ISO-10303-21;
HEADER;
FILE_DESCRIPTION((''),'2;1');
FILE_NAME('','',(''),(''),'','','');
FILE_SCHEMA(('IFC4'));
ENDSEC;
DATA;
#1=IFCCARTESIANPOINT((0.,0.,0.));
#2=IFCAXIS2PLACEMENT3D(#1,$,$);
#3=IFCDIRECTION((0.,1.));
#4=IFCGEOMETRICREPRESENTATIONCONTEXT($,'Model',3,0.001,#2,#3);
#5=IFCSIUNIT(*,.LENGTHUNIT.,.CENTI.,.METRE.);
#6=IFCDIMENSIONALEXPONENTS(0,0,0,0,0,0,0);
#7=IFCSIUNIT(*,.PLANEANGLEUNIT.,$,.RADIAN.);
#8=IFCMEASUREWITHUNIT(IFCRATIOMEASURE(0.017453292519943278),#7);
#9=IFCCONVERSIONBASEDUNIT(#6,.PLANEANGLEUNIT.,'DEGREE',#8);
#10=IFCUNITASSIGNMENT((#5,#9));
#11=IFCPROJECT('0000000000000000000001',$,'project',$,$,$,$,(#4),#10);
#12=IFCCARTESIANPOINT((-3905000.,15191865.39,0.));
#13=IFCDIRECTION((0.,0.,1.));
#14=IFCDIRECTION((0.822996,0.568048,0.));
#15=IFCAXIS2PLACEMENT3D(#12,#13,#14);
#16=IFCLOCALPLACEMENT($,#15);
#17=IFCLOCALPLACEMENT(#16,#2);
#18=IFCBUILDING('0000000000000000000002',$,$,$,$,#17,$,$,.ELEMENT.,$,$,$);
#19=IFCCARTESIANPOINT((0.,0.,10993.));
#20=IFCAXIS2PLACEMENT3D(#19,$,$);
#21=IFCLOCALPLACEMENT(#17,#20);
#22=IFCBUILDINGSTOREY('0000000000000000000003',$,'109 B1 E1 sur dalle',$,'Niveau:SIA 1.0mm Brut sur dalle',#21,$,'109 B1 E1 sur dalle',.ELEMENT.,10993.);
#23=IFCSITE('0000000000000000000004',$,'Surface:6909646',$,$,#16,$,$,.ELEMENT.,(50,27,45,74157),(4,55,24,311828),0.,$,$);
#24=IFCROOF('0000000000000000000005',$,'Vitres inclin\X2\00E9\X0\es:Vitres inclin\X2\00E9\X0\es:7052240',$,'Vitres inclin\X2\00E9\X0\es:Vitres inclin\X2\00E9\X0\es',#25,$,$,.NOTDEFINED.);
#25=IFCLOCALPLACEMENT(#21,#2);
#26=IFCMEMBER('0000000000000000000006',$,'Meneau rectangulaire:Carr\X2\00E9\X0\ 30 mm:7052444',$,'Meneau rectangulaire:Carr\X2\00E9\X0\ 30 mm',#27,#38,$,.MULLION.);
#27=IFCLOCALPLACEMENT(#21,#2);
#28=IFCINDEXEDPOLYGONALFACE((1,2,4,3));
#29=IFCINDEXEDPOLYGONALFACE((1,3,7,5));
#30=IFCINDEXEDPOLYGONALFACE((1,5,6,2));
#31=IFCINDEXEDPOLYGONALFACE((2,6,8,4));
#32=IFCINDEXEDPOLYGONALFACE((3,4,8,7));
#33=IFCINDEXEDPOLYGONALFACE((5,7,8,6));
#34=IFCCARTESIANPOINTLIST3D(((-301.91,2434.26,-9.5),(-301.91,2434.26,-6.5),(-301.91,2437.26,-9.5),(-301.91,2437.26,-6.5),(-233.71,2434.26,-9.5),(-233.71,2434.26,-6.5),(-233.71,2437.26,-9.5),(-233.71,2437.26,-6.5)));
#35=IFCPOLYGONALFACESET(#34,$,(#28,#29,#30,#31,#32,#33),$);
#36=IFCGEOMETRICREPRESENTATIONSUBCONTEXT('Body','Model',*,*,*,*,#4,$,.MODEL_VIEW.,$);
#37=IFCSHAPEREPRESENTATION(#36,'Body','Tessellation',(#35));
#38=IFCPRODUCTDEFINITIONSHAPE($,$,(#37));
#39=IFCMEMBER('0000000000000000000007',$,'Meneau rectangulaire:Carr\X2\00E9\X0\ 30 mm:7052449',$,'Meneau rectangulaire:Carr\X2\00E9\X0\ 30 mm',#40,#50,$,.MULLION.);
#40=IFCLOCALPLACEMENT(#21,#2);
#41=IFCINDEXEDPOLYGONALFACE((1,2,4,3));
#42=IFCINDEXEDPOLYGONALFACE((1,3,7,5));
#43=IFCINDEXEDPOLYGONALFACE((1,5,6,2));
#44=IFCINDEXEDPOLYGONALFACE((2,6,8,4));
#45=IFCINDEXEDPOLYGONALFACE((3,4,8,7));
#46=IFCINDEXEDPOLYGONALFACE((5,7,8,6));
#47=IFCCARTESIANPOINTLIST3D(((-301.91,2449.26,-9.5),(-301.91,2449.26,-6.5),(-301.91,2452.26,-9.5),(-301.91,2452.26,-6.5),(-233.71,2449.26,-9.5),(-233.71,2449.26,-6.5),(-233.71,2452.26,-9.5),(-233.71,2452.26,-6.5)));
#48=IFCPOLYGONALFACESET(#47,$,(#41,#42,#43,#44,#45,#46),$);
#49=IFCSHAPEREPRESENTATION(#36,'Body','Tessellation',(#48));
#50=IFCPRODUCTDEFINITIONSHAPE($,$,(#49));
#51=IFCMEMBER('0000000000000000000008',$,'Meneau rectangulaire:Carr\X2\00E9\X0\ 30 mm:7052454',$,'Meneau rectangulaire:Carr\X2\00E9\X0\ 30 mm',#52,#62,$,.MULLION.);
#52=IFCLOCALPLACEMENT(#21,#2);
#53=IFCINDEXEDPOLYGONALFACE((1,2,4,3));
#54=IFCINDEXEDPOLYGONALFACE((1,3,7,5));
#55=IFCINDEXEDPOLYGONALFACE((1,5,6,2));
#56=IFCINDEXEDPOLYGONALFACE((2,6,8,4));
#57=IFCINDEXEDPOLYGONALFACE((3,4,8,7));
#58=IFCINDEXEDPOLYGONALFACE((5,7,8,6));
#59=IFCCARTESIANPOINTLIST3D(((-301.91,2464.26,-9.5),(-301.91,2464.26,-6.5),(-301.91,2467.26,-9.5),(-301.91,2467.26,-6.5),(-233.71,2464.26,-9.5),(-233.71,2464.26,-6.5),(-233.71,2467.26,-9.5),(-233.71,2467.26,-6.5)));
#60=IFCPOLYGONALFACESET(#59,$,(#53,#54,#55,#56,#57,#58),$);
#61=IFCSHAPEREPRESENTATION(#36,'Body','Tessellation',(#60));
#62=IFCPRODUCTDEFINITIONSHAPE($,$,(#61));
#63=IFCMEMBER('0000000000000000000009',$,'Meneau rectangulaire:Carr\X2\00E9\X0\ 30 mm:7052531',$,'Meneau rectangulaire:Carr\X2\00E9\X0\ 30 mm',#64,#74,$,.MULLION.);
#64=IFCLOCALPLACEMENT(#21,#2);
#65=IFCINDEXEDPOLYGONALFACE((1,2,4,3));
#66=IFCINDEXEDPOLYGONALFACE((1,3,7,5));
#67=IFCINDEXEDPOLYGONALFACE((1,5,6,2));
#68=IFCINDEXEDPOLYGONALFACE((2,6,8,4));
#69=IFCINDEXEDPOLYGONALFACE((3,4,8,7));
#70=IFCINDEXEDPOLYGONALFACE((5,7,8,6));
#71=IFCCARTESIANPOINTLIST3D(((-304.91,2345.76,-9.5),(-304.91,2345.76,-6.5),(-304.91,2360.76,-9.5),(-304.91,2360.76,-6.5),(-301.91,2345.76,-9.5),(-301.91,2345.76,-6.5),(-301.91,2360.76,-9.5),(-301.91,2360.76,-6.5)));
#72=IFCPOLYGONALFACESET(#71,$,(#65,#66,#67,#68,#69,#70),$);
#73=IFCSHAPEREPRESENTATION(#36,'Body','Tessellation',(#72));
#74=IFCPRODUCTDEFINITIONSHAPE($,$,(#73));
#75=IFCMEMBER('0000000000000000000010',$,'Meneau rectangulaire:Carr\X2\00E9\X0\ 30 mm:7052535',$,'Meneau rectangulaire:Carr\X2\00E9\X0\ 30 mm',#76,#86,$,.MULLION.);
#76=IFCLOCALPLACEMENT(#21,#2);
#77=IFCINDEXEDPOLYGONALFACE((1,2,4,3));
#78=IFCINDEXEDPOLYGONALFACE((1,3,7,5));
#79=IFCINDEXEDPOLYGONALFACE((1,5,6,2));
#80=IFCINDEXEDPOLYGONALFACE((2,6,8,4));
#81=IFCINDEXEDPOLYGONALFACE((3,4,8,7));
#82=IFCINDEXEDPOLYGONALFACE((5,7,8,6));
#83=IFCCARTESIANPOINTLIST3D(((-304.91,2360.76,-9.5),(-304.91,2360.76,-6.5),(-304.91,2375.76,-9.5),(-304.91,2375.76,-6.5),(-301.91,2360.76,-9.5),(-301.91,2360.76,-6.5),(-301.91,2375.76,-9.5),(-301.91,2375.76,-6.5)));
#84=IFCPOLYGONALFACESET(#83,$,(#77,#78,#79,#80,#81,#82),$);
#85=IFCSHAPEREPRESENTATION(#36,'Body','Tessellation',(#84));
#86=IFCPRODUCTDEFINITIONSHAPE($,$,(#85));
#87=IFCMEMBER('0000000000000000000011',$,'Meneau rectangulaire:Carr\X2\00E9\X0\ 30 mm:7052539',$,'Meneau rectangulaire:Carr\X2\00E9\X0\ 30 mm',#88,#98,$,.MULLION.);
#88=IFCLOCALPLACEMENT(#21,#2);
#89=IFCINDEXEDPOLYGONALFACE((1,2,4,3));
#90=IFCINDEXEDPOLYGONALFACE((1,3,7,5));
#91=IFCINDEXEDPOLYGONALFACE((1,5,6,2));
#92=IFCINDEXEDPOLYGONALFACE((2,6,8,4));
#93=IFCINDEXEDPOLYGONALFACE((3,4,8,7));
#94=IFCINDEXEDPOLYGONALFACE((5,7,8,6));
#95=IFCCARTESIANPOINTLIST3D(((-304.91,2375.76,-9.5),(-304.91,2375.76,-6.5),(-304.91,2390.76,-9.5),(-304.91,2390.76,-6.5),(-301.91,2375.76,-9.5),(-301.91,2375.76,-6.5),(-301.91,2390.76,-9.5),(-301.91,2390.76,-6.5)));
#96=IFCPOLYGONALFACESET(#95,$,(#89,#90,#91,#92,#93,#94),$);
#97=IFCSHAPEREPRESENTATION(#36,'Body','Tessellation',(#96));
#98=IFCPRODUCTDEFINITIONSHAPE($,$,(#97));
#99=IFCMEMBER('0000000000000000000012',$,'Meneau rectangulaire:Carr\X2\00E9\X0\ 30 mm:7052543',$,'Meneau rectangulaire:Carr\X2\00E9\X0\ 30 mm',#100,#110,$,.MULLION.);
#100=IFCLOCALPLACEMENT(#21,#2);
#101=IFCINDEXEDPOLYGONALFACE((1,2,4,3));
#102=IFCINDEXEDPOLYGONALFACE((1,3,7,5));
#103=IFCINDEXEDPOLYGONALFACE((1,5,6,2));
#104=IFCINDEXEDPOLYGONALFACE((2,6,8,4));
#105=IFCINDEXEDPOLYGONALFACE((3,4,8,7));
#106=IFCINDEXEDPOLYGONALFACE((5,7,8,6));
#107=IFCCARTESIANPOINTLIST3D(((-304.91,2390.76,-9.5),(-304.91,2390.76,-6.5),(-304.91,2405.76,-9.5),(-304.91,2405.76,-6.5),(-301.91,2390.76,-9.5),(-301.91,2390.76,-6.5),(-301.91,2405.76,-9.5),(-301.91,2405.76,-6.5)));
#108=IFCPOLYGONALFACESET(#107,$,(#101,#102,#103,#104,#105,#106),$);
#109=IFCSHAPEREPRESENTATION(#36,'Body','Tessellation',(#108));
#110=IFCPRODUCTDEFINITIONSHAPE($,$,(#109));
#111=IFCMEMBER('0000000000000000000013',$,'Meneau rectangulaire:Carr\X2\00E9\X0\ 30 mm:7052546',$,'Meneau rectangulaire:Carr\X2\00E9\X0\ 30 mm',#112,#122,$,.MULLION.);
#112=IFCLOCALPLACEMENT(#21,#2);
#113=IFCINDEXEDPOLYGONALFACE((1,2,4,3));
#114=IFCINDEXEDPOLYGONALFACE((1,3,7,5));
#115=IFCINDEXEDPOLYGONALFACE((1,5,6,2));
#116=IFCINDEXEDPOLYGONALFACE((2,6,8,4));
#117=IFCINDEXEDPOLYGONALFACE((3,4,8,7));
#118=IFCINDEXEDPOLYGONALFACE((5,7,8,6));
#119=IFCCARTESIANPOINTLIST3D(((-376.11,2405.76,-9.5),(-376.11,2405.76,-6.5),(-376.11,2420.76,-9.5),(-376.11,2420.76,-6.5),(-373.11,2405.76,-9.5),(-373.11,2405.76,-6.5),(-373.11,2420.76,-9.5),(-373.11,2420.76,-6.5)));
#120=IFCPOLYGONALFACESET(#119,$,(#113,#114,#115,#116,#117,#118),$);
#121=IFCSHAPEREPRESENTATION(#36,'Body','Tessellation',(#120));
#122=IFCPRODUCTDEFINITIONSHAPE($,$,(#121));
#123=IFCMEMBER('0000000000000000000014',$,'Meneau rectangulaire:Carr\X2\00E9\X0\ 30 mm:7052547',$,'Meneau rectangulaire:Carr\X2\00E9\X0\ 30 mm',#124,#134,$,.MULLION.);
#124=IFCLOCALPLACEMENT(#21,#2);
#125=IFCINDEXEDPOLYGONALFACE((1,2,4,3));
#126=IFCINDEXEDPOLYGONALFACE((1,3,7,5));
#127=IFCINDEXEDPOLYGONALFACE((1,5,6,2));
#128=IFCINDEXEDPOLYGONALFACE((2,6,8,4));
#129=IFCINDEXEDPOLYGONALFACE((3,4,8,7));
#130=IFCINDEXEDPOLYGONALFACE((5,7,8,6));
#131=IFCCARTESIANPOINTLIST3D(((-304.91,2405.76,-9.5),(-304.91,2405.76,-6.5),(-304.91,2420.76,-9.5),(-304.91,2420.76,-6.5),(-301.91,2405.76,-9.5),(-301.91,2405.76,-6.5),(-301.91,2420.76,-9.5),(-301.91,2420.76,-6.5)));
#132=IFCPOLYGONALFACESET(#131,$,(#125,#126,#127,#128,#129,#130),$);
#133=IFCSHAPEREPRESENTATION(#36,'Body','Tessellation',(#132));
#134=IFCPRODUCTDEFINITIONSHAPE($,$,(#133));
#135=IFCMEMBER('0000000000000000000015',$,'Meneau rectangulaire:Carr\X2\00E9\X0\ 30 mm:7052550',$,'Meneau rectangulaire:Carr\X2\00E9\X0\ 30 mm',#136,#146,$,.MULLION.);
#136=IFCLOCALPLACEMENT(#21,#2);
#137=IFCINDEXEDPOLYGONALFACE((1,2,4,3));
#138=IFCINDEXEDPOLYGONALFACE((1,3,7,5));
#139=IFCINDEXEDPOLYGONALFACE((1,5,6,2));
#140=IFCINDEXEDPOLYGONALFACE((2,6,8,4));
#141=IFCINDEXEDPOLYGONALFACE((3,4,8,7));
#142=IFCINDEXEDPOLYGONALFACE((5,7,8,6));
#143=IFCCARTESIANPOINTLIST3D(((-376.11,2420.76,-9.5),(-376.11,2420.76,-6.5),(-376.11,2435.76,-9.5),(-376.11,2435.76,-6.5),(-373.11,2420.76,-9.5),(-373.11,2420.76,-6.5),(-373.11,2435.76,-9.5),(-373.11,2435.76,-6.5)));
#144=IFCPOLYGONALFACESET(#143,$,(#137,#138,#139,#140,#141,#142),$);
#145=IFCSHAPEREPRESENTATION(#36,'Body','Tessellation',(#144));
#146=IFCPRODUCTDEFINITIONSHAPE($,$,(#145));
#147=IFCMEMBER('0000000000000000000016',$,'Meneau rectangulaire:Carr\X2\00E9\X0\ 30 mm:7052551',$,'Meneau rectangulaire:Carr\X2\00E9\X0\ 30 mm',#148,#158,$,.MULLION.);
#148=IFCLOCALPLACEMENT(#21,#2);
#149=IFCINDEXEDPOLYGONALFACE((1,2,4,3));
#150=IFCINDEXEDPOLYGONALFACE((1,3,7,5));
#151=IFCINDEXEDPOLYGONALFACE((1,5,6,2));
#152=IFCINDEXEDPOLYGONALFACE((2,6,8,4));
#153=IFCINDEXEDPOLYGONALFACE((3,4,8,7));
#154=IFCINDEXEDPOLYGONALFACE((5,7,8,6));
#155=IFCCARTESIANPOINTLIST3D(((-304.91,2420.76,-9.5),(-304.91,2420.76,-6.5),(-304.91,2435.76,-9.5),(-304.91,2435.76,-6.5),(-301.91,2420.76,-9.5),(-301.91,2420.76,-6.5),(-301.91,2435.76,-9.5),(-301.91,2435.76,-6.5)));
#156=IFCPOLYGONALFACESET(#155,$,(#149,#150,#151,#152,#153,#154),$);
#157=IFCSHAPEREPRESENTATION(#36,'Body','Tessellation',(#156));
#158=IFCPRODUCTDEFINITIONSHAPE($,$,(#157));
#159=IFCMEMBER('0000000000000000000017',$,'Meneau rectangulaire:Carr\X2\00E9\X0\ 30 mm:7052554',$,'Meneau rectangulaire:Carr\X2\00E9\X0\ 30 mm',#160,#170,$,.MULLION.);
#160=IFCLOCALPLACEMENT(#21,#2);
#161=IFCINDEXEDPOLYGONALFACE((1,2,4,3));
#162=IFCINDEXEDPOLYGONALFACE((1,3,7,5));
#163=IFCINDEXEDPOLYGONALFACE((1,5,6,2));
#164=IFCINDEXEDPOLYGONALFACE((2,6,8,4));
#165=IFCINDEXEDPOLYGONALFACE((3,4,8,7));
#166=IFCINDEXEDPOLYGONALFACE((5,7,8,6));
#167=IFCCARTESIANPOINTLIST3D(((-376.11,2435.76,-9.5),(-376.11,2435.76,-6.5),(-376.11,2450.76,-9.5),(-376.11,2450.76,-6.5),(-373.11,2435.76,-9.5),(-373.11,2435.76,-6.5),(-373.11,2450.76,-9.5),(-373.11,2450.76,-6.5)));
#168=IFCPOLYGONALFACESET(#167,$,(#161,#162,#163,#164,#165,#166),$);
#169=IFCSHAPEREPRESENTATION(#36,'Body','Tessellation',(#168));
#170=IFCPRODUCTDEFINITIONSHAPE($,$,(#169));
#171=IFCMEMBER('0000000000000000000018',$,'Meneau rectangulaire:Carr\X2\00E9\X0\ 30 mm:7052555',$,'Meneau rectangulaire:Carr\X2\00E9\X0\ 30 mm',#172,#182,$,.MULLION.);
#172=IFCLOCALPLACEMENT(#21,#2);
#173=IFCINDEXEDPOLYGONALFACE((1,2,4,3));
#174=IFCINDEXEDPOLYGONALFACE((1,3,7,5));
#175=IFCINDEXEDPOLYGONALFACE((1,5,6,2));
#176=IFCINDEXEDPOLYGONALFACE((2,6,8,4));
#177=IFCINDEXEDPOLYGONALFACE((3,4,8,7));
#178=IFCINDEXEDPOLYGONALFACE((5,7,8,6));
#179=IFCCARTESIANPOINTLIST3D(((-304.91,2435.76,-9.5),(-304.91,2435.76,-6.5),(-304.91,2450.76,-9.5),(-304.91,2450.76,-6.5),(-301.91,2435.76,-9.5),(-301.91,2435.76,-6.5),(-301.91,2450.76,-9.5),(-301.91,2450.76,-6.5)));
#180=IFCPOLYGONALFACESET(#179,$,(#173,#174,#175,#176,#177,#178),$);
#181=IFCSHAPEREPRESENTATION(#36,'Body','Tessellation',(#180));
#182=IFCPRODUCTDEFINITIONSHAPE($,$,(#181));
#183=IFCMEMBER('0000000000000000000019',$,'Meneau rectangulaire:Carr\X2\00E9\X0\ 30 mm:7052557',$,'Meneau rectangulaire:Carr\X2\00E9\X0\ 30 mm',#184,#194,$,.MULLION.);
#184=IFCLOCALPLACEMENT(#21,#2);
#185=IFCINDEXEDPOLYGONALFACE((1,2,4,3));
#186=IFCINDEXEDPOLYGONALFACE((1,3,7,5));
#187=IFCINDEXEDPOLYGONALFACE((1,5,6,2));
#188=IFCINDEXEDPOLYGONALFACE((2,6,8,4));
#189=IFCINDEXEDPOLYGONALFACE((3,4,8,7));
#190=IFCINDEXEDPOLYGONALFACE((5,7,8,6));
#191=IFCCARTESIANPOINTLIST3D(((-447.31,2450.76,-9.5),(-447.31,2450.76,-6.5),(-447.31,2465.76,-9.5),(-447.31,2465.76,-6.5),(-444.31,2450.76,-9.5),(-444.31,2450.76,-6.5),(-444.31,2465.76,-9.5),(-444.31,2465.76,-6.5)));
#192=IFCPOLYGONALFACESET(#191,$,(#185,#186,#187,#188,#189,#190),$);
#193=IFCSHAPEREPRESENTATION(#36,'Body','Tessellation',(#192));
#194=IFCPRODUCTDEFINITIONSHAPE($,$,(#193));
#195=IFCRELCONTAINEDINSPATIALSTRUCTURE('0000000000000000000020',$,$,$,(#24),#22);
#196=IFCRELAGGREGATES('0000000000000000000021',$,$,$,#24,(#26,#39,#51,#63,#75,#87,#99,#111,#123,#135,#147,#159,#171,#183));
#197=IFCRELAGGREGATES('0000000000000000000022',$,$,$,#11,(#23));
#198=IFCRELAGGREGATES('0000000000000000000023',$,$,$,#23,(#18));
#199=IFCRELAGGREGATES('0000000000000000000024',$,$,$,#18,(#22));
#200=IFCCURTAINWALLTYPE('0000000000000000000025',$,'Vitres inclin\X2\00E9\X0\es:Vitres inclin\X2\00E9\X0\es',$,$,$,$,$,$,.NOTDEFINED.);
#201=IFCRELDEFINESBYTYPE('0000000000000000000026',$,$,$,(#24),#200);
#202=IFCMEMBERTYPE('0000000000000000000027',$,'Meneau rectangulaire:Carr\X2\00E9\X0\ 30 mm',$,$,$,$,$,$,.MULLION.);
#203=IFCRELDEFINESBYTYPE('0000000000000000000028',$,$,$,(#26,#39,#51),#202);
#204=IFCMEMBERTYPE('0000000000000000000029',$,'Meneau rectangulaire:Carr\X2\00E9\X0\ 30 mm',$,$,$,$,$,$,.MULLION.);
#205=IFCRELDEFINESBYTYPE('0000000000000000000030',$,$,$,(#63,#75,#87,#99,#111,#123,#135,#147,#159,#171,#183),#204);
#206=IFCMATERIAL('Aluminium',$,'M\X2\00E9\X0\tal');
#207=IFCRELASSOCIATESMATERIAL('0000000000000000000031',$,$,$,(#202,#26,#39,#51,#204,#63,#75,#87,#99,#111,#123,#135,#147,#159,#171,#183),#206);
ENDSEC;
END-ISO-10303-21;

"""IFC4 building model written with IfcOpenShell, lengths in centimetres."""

from ifc_helpers import new_model, entity, si_unit, converted_unit, direction, frame, origin, place, context, subcontext, project, spatial, indexed_curve, outline, extrude, source, transform, mapped, material, type_object, type_shapes, element, aggregate, save


model = new_model("IFC4")

# Units and contexts
model_context = context("Model", 3, precision=0.001, world=origin(), true_north=direction((0.0, 1.0)))
body_context = subcontext(model_context, "Body", "Model", "MODEL_VIEW")
ifc_project = project(units=[si_unit("LENGTHUNIT", "METRE", prefix="CENTI"), converted_unit("PLANEANGLEUNIT", "DEGREE", entity("IfcRatioMeasure", 0.017453292519943278), si_unit("PLANEANGLEUNIT", "RADIAN"), dimensions=[0, 0, 0, 0, 0, 0, 0])], contexts=[model_context])

# Site, building, storey
site_placement = place(None, frame((-3905000.0, 15191865.39, 0.0), z_axis=(0.0, 0.0, 1.0), x_axis=(0.822996, 0.568048, 0.0)))
site = spatial("IfcSite", under=ifc_project, at=site_placement, Name="Surface:6909646", CompositionType="ELEMENT", RefLatitude=(50, 27, 45, 74157), RefLongitude=(4, 55, 24, 311828), RefElevation=0.0)
building_placement = place(site_placement, origin())
building = spatial("IfcBuilding", under=site, at=building_placement, CompositionType="ELEMENT")
storey_placement = place(building_placement, frame((0.0, 0.0, 10993.0)))
storey = spatial("IfcBuildingStorey", under=building, at=storey_placement, Name="109 B1 E1 sur dalle", ObjectType="Niveau:SIA 1.0mm Brut sur dalle", LongName="109 B1 E1 sur dalle", CompositionType="ELEMENT", Elevation=10993.0)

# Roof, members
curtain_wall_type = type_object("IfcCurtainWallType", Name="Vitres inclinées:Vitres inclinées", PredefinedType="NOTDEFINED")
roof_placement = place(storey_placement, frame((0.0, 0.0, -10993.0)))
roof = element("IfcRoof", 1, at=roof_placement, inside=storey, type_object=curtain_wall_type, Name="Vitres inclinées:Vitres inclinées:7052240", ObjectType="Vitres inclinées:Vitres inclinées", PredefinedType="NOTDEFINED")
ifc_material = material(Name="Aluminium", Category="Métal")
member_type_1 = type_object("IfcMemberType", Name="Meneau rectangulaire:Carré 30 mm", PredefinedType="MULLION", material=ifc_material)
shared_shape_1 = source(origin(), body_context, "Body", "SweptSolid", [
    extrude(outline(indexed_curve([(-1.5, -1.5), (1.5, -1.5), (1.5, 1.5), (-1.5, 1.5), (-1.5, -1.5)], self_intersect=False)), frame((0.0, 0.0, -68.2), z_axis=(0.0, 0.0, 1.0), x_axis=(0.0, -1.0, 0.0)), (0.0, 0.0, 1.0), 68.2),
])
type_shapes(member_type_1, [shared_shape_1])
member_1_placement = place(roof_placement, frame((-301.91, 2435.76, 10985.0), z_axis=(-1.0, 0.0, 0.0), x_axis=(0.0, 1.0, 0.0)))
member_1 = element("IfcMember", 2, at=member_1_placement, type_object=member_type_1, material=ifc_material, Name="Meneau rectangulaire:Carré 30 mm:7052444", ObjectType="Meneau rectangulaire:Carré 30 mm", PredefinedType="MULLION", context=body_context, shape_type="MappedRepresentation", body=[
    mapped(shared_shape_1, transform((0.0, 0.0, 0.0), scale=1.0)),
])
member_2_placement = place(roof_placement, frame((-301.91, 2450.76, 10985.0), z_axis=(-1.0, 0.0, 0.0), x_axis=(0.0, 1.0, 0.0)))
member_2 = element("IfcMember", 3, at=member_2_placement, type_object=member_type_1, material=ifc_material, Name="Meneau rectangulaire:Carré 30 mm:7052449", ObjectType="Meneau rectangulaire:Carré 30 mm", PredefinedType="MULLION", context=body_context, shape_type="MappedRepresentation", body=[
    mapped(shared_shape_1, transform((0.0, 0.0, 0.0), scale=1.0)),
])
member_3_placement = place(roof_placement, frame((-301.91, 2465.76, 10985.0), z_axis=(-1.0, 0.0, 0.0), x_axis=(0.0, 1.0, 0.0)))
member_3 = element("IfcMember", 4, at=member_3_placement, type_object=member_type_1, material=ifc_material, Name="Meneau rectangulaire:Carré 30 mm:7052454", ObjectType="Meneau rectangulaire:Carré 30 mm", PredefinedType="MULLION", context=body_context, shape_type="MappedRepresentation", body=[
    mapped(shared_shape_1, transform((0.0, 0.0, 0.0), scale=1.0)),
])
member_type_2 = type_object("IfcMemberType", Name="Meneau rectangulaire:Carré 30 mm", PredefinedType="MULLION", material=ifc_material)
shared_shape_2 = source(origin(), body_context, "Body", "SweptSolid", [
    extrude(outline(indexed_curve([(-1.5, -1.5), (1.5, -1.5), (1.5, 1.5), (-1.5, 1.5), (-1.5, -1.5)], self_intersect=False)), frame((0.0, 0.0, -15.0), z_axis=(0.0, 0.0, 1.0), x_axis=(0.0, -1.0, 0.0)), (0.0, 0.0, 1.0), 15.0),
])
type_shapes(member_type_2, [shared_shape_2])
member_4_placement = place(roof_placement, frame((-303.41, 2360.76, 10985.0), z_axis=(0.0, 1.0, 0.0), x_axis=(1.0, 0.0, 0.0)))
member_4 = element("IfcMember", 5, at=member_4_placement, type_object=member_type_2, material=ifc_material, Name="Meneau rectangulaire:Carré 30 mm:7052531", ObjectType="Meneau rectangulaire:Carré 30 mm", PredefinedType="MULLION", context=body_context, shape_type="MappedRepresentation", body=[
    mapped(shared_shape_2, transform((0.0, 0.0, 0.0), scale=1.0)),
])
member_5_placement = place(roof_placement, frame((-303.41, 2375.76, 10985.0), z_axis=(0.0, 1.0, 0.0), x_axis=(1.0, 0.0, 0.0)))
member_5 = element("IfcMember", 6, at=member_5_placement, type_object=member_type_2, material=ifc_material, Name="Meneau rectangulaire:Carré 30 mm:7052535", ObjectType="Meneau rectangulaire:Carré 30 mm", PredefinedType="MULLION", context=body_context, shape_type="MappedRepresentation", body=[
    mapped(shared_shape_2, transform((0.0, 0.0, 0.0), scale=1.0)),
])
member_6_placement = place(roof_placement, frame((-303.41, 2390.76, 10985.0), z_axis=(0.0, 1.0, 0.0), x_axis=(1.0, 0.0, 0.0)))
member_6 = element("IfcMember", 7, at=member_6_placement, type_object=member_type_2, material=ifc_material, Name="Meneau rectangulaire:Carré 30 mm:7052539", ObjectType="Meneau rectangulaire:Carré 30 mm", PredefinedType="MULLION", context=body_context, shape_type="MappedRepresentation", body=[
    mapped(shared_shape_2, transform((0.0, 0.0, 0.0), scale=1.0)),
])
member_7_placement = place(roof_placement, frame((-303.41, 2405.76, 10985.0), z_axis=(0.0, 1.0, 0.0), x_axis=(1.0, 0.0, 0.0)))
member_7 = element("IfcMember", 8, at=member_7_placement, type_object=member_type_2, material=ifc_material, Name="Meneau rectangulaire:Carré 30 mm:7052543", ObjectType="Meneau rectangulaire:Carré 30 mm", PredefinedType="MULLION", context=body_context, shape_type="MappedRepresentation", body=[
    mapped(shared_shape_2, transform((0.0, 0.0, 0.0), scale=1.0)),
])
member_8_placement = place(roof_placement, frame((-374.61, 2420.76, 10985.0), z_axis=(0.0, 1.0, 0.0), x_axis=(1.0, 0.0, 0.0)))
member_8 = element("IfcMember", 9, at=member_8_placement, type_object=member_type_2, material=ifc_material, Name="Meneau rectangulaire:Carré 30 mm:7052546", ObjectType="Meneau rectangulaire:Carré 30 mm", PredefinedType="MULLION", context=body_context, shape_type="MappedRepresentation", body=[
    mapped(shared_shape_2, transform((0.0, 0.0, 0.0), scale=1.0)),
])
member_9_placement = place(roof_placement, frame((-303.41, 2420.76, 10985.0), z_axis=(0.0, 1.0, 0.0), x_axis=(1.0, 0.0, 0.0)))
member_9 = element("IfcMember", 10, at=member_9_placement, type_object=member_type_2, material=ifc_material, Name="Meneau rectangulaire:Carré 30 mm:7052547", ObjectType="Meneau rectangulaire:Carré 30 mm", PredefinedType="MULLION", context=body_context, shape_type="MappedRepresentation", body=[
    mapped(shared_shape_2, transform((0.0, 0.0, 0.0), scale=1.0)),
])
member_10_placement = place(roof_placement, frame((-374.61, 2435.76, 10985.0), z_axis=(0.0, 1.0, 0.0), x_axis=(1.0, 0.0, 0.0)))
member_10 = element("IfcMember", 11, at=member_10_placement, type_object=member_type_2, material=ifc_material, Name="Meneau rectangulaire:Carré 30 mm:7052550", ObjectType="Meneau rectangulaire:Carré 30 mm", PredefinedType="MULLION", context=body_context, shape_type="MappedRepresentation", body=[
    mapped(shared_shape_2, transform((0.0, 0.0, 0.0), scale=1.0)),
])
member_11_placement = place(roof_placement, frame((-303.41, 2435.76, 10985.0), z_axis=(0.0, 1.0, 0.0), x_axis=(1.0, 0.0, 0.0)))
member_11 = element("IfcMember", 12, at=member_11_placement, type_object=member_type_2, material=ifc_material, Name="Meneau rectangulaire:Carré 30 mm:7052551", ObjectType="Meneau rectangulaire:Carré 30 mm", PredefinedType="MULLION", context=body_context, shape_type="MappedRepresentation", body=[
    mapped(shared_shape_2, transform((0.0, 0.0, 0.0), scale=1.0)),
])
member_12_placement = place(roof_placement, frame((-374.61, 2450.76, 10985.0), z_axis=(0.0, 1.0, 0.0), x_axis=(1.0, 0.0, 0.0)))
member_12 = element("IfcMember", 13, at=member_12_placement, type_object=member_type_2, material=ifc_material, Name="Meneau rectangulaire:Carré 30 mm:7052554", ObjectType="Meneau rectangulaire:Carré 30 mm", PredefinedType="MULLION", context=body_context, shape_type="MappedRepresentation", body=[
    mapped(shared_shape_2, transform((0.0, 0.0, 0.0), scale=1.0)),
])
member_13_placement = place(roof_placement, frame((-303.41, 2450.76, 10985.0), z_axis=(0.0, 1.0, 0.0), x_axis=(1.0, 0.0, 0.0)))
member_13 = element("IfcMember", 14, at=member_13_placement, type_object=member_type_2, material=ifc_material, Name="Meneau rectangulaire:Carré 30 mm:7052555", ObjectType="Meneau rectangulaire:Carré 30 mm", PredefinedType="MULLION", context=body_context, shape_type="MappedRepresentation", body=[
    mapped(shared_shape_2, transform((0.0, 0.0, 0.0), scale=1.0)),
])
member_14_placement = place(roof_placement, frame((-445.81, 2465.76, 10985.0), z_axis=(0.0, 1.0, 0.0), x_axis=(1.0, 0.0, 0.0)))
member_14 = element("IfcMember", 15, at=member_14_placement, type_object=member_type_2, material=ifc_material, Name="Meneau rectangulaire:Carré 30 mm:7052557", ObjectType="Meneau rectangulaire:Carré 30 mm", PredefinedType="MULLION", context=body_context, shape_type="MappedRepresentation", body=[
    mapped(shared_shape_2, transform((0.0, 0.0, 0.0), scale=1.0)),
])
aggregate(roof, [member_1, member_2, member_3, member_4, member_5, member_6, member_7, member_8, member_9, member_10, member_11, member_12, member_13, member_14])

save(model, "model.ifc")
